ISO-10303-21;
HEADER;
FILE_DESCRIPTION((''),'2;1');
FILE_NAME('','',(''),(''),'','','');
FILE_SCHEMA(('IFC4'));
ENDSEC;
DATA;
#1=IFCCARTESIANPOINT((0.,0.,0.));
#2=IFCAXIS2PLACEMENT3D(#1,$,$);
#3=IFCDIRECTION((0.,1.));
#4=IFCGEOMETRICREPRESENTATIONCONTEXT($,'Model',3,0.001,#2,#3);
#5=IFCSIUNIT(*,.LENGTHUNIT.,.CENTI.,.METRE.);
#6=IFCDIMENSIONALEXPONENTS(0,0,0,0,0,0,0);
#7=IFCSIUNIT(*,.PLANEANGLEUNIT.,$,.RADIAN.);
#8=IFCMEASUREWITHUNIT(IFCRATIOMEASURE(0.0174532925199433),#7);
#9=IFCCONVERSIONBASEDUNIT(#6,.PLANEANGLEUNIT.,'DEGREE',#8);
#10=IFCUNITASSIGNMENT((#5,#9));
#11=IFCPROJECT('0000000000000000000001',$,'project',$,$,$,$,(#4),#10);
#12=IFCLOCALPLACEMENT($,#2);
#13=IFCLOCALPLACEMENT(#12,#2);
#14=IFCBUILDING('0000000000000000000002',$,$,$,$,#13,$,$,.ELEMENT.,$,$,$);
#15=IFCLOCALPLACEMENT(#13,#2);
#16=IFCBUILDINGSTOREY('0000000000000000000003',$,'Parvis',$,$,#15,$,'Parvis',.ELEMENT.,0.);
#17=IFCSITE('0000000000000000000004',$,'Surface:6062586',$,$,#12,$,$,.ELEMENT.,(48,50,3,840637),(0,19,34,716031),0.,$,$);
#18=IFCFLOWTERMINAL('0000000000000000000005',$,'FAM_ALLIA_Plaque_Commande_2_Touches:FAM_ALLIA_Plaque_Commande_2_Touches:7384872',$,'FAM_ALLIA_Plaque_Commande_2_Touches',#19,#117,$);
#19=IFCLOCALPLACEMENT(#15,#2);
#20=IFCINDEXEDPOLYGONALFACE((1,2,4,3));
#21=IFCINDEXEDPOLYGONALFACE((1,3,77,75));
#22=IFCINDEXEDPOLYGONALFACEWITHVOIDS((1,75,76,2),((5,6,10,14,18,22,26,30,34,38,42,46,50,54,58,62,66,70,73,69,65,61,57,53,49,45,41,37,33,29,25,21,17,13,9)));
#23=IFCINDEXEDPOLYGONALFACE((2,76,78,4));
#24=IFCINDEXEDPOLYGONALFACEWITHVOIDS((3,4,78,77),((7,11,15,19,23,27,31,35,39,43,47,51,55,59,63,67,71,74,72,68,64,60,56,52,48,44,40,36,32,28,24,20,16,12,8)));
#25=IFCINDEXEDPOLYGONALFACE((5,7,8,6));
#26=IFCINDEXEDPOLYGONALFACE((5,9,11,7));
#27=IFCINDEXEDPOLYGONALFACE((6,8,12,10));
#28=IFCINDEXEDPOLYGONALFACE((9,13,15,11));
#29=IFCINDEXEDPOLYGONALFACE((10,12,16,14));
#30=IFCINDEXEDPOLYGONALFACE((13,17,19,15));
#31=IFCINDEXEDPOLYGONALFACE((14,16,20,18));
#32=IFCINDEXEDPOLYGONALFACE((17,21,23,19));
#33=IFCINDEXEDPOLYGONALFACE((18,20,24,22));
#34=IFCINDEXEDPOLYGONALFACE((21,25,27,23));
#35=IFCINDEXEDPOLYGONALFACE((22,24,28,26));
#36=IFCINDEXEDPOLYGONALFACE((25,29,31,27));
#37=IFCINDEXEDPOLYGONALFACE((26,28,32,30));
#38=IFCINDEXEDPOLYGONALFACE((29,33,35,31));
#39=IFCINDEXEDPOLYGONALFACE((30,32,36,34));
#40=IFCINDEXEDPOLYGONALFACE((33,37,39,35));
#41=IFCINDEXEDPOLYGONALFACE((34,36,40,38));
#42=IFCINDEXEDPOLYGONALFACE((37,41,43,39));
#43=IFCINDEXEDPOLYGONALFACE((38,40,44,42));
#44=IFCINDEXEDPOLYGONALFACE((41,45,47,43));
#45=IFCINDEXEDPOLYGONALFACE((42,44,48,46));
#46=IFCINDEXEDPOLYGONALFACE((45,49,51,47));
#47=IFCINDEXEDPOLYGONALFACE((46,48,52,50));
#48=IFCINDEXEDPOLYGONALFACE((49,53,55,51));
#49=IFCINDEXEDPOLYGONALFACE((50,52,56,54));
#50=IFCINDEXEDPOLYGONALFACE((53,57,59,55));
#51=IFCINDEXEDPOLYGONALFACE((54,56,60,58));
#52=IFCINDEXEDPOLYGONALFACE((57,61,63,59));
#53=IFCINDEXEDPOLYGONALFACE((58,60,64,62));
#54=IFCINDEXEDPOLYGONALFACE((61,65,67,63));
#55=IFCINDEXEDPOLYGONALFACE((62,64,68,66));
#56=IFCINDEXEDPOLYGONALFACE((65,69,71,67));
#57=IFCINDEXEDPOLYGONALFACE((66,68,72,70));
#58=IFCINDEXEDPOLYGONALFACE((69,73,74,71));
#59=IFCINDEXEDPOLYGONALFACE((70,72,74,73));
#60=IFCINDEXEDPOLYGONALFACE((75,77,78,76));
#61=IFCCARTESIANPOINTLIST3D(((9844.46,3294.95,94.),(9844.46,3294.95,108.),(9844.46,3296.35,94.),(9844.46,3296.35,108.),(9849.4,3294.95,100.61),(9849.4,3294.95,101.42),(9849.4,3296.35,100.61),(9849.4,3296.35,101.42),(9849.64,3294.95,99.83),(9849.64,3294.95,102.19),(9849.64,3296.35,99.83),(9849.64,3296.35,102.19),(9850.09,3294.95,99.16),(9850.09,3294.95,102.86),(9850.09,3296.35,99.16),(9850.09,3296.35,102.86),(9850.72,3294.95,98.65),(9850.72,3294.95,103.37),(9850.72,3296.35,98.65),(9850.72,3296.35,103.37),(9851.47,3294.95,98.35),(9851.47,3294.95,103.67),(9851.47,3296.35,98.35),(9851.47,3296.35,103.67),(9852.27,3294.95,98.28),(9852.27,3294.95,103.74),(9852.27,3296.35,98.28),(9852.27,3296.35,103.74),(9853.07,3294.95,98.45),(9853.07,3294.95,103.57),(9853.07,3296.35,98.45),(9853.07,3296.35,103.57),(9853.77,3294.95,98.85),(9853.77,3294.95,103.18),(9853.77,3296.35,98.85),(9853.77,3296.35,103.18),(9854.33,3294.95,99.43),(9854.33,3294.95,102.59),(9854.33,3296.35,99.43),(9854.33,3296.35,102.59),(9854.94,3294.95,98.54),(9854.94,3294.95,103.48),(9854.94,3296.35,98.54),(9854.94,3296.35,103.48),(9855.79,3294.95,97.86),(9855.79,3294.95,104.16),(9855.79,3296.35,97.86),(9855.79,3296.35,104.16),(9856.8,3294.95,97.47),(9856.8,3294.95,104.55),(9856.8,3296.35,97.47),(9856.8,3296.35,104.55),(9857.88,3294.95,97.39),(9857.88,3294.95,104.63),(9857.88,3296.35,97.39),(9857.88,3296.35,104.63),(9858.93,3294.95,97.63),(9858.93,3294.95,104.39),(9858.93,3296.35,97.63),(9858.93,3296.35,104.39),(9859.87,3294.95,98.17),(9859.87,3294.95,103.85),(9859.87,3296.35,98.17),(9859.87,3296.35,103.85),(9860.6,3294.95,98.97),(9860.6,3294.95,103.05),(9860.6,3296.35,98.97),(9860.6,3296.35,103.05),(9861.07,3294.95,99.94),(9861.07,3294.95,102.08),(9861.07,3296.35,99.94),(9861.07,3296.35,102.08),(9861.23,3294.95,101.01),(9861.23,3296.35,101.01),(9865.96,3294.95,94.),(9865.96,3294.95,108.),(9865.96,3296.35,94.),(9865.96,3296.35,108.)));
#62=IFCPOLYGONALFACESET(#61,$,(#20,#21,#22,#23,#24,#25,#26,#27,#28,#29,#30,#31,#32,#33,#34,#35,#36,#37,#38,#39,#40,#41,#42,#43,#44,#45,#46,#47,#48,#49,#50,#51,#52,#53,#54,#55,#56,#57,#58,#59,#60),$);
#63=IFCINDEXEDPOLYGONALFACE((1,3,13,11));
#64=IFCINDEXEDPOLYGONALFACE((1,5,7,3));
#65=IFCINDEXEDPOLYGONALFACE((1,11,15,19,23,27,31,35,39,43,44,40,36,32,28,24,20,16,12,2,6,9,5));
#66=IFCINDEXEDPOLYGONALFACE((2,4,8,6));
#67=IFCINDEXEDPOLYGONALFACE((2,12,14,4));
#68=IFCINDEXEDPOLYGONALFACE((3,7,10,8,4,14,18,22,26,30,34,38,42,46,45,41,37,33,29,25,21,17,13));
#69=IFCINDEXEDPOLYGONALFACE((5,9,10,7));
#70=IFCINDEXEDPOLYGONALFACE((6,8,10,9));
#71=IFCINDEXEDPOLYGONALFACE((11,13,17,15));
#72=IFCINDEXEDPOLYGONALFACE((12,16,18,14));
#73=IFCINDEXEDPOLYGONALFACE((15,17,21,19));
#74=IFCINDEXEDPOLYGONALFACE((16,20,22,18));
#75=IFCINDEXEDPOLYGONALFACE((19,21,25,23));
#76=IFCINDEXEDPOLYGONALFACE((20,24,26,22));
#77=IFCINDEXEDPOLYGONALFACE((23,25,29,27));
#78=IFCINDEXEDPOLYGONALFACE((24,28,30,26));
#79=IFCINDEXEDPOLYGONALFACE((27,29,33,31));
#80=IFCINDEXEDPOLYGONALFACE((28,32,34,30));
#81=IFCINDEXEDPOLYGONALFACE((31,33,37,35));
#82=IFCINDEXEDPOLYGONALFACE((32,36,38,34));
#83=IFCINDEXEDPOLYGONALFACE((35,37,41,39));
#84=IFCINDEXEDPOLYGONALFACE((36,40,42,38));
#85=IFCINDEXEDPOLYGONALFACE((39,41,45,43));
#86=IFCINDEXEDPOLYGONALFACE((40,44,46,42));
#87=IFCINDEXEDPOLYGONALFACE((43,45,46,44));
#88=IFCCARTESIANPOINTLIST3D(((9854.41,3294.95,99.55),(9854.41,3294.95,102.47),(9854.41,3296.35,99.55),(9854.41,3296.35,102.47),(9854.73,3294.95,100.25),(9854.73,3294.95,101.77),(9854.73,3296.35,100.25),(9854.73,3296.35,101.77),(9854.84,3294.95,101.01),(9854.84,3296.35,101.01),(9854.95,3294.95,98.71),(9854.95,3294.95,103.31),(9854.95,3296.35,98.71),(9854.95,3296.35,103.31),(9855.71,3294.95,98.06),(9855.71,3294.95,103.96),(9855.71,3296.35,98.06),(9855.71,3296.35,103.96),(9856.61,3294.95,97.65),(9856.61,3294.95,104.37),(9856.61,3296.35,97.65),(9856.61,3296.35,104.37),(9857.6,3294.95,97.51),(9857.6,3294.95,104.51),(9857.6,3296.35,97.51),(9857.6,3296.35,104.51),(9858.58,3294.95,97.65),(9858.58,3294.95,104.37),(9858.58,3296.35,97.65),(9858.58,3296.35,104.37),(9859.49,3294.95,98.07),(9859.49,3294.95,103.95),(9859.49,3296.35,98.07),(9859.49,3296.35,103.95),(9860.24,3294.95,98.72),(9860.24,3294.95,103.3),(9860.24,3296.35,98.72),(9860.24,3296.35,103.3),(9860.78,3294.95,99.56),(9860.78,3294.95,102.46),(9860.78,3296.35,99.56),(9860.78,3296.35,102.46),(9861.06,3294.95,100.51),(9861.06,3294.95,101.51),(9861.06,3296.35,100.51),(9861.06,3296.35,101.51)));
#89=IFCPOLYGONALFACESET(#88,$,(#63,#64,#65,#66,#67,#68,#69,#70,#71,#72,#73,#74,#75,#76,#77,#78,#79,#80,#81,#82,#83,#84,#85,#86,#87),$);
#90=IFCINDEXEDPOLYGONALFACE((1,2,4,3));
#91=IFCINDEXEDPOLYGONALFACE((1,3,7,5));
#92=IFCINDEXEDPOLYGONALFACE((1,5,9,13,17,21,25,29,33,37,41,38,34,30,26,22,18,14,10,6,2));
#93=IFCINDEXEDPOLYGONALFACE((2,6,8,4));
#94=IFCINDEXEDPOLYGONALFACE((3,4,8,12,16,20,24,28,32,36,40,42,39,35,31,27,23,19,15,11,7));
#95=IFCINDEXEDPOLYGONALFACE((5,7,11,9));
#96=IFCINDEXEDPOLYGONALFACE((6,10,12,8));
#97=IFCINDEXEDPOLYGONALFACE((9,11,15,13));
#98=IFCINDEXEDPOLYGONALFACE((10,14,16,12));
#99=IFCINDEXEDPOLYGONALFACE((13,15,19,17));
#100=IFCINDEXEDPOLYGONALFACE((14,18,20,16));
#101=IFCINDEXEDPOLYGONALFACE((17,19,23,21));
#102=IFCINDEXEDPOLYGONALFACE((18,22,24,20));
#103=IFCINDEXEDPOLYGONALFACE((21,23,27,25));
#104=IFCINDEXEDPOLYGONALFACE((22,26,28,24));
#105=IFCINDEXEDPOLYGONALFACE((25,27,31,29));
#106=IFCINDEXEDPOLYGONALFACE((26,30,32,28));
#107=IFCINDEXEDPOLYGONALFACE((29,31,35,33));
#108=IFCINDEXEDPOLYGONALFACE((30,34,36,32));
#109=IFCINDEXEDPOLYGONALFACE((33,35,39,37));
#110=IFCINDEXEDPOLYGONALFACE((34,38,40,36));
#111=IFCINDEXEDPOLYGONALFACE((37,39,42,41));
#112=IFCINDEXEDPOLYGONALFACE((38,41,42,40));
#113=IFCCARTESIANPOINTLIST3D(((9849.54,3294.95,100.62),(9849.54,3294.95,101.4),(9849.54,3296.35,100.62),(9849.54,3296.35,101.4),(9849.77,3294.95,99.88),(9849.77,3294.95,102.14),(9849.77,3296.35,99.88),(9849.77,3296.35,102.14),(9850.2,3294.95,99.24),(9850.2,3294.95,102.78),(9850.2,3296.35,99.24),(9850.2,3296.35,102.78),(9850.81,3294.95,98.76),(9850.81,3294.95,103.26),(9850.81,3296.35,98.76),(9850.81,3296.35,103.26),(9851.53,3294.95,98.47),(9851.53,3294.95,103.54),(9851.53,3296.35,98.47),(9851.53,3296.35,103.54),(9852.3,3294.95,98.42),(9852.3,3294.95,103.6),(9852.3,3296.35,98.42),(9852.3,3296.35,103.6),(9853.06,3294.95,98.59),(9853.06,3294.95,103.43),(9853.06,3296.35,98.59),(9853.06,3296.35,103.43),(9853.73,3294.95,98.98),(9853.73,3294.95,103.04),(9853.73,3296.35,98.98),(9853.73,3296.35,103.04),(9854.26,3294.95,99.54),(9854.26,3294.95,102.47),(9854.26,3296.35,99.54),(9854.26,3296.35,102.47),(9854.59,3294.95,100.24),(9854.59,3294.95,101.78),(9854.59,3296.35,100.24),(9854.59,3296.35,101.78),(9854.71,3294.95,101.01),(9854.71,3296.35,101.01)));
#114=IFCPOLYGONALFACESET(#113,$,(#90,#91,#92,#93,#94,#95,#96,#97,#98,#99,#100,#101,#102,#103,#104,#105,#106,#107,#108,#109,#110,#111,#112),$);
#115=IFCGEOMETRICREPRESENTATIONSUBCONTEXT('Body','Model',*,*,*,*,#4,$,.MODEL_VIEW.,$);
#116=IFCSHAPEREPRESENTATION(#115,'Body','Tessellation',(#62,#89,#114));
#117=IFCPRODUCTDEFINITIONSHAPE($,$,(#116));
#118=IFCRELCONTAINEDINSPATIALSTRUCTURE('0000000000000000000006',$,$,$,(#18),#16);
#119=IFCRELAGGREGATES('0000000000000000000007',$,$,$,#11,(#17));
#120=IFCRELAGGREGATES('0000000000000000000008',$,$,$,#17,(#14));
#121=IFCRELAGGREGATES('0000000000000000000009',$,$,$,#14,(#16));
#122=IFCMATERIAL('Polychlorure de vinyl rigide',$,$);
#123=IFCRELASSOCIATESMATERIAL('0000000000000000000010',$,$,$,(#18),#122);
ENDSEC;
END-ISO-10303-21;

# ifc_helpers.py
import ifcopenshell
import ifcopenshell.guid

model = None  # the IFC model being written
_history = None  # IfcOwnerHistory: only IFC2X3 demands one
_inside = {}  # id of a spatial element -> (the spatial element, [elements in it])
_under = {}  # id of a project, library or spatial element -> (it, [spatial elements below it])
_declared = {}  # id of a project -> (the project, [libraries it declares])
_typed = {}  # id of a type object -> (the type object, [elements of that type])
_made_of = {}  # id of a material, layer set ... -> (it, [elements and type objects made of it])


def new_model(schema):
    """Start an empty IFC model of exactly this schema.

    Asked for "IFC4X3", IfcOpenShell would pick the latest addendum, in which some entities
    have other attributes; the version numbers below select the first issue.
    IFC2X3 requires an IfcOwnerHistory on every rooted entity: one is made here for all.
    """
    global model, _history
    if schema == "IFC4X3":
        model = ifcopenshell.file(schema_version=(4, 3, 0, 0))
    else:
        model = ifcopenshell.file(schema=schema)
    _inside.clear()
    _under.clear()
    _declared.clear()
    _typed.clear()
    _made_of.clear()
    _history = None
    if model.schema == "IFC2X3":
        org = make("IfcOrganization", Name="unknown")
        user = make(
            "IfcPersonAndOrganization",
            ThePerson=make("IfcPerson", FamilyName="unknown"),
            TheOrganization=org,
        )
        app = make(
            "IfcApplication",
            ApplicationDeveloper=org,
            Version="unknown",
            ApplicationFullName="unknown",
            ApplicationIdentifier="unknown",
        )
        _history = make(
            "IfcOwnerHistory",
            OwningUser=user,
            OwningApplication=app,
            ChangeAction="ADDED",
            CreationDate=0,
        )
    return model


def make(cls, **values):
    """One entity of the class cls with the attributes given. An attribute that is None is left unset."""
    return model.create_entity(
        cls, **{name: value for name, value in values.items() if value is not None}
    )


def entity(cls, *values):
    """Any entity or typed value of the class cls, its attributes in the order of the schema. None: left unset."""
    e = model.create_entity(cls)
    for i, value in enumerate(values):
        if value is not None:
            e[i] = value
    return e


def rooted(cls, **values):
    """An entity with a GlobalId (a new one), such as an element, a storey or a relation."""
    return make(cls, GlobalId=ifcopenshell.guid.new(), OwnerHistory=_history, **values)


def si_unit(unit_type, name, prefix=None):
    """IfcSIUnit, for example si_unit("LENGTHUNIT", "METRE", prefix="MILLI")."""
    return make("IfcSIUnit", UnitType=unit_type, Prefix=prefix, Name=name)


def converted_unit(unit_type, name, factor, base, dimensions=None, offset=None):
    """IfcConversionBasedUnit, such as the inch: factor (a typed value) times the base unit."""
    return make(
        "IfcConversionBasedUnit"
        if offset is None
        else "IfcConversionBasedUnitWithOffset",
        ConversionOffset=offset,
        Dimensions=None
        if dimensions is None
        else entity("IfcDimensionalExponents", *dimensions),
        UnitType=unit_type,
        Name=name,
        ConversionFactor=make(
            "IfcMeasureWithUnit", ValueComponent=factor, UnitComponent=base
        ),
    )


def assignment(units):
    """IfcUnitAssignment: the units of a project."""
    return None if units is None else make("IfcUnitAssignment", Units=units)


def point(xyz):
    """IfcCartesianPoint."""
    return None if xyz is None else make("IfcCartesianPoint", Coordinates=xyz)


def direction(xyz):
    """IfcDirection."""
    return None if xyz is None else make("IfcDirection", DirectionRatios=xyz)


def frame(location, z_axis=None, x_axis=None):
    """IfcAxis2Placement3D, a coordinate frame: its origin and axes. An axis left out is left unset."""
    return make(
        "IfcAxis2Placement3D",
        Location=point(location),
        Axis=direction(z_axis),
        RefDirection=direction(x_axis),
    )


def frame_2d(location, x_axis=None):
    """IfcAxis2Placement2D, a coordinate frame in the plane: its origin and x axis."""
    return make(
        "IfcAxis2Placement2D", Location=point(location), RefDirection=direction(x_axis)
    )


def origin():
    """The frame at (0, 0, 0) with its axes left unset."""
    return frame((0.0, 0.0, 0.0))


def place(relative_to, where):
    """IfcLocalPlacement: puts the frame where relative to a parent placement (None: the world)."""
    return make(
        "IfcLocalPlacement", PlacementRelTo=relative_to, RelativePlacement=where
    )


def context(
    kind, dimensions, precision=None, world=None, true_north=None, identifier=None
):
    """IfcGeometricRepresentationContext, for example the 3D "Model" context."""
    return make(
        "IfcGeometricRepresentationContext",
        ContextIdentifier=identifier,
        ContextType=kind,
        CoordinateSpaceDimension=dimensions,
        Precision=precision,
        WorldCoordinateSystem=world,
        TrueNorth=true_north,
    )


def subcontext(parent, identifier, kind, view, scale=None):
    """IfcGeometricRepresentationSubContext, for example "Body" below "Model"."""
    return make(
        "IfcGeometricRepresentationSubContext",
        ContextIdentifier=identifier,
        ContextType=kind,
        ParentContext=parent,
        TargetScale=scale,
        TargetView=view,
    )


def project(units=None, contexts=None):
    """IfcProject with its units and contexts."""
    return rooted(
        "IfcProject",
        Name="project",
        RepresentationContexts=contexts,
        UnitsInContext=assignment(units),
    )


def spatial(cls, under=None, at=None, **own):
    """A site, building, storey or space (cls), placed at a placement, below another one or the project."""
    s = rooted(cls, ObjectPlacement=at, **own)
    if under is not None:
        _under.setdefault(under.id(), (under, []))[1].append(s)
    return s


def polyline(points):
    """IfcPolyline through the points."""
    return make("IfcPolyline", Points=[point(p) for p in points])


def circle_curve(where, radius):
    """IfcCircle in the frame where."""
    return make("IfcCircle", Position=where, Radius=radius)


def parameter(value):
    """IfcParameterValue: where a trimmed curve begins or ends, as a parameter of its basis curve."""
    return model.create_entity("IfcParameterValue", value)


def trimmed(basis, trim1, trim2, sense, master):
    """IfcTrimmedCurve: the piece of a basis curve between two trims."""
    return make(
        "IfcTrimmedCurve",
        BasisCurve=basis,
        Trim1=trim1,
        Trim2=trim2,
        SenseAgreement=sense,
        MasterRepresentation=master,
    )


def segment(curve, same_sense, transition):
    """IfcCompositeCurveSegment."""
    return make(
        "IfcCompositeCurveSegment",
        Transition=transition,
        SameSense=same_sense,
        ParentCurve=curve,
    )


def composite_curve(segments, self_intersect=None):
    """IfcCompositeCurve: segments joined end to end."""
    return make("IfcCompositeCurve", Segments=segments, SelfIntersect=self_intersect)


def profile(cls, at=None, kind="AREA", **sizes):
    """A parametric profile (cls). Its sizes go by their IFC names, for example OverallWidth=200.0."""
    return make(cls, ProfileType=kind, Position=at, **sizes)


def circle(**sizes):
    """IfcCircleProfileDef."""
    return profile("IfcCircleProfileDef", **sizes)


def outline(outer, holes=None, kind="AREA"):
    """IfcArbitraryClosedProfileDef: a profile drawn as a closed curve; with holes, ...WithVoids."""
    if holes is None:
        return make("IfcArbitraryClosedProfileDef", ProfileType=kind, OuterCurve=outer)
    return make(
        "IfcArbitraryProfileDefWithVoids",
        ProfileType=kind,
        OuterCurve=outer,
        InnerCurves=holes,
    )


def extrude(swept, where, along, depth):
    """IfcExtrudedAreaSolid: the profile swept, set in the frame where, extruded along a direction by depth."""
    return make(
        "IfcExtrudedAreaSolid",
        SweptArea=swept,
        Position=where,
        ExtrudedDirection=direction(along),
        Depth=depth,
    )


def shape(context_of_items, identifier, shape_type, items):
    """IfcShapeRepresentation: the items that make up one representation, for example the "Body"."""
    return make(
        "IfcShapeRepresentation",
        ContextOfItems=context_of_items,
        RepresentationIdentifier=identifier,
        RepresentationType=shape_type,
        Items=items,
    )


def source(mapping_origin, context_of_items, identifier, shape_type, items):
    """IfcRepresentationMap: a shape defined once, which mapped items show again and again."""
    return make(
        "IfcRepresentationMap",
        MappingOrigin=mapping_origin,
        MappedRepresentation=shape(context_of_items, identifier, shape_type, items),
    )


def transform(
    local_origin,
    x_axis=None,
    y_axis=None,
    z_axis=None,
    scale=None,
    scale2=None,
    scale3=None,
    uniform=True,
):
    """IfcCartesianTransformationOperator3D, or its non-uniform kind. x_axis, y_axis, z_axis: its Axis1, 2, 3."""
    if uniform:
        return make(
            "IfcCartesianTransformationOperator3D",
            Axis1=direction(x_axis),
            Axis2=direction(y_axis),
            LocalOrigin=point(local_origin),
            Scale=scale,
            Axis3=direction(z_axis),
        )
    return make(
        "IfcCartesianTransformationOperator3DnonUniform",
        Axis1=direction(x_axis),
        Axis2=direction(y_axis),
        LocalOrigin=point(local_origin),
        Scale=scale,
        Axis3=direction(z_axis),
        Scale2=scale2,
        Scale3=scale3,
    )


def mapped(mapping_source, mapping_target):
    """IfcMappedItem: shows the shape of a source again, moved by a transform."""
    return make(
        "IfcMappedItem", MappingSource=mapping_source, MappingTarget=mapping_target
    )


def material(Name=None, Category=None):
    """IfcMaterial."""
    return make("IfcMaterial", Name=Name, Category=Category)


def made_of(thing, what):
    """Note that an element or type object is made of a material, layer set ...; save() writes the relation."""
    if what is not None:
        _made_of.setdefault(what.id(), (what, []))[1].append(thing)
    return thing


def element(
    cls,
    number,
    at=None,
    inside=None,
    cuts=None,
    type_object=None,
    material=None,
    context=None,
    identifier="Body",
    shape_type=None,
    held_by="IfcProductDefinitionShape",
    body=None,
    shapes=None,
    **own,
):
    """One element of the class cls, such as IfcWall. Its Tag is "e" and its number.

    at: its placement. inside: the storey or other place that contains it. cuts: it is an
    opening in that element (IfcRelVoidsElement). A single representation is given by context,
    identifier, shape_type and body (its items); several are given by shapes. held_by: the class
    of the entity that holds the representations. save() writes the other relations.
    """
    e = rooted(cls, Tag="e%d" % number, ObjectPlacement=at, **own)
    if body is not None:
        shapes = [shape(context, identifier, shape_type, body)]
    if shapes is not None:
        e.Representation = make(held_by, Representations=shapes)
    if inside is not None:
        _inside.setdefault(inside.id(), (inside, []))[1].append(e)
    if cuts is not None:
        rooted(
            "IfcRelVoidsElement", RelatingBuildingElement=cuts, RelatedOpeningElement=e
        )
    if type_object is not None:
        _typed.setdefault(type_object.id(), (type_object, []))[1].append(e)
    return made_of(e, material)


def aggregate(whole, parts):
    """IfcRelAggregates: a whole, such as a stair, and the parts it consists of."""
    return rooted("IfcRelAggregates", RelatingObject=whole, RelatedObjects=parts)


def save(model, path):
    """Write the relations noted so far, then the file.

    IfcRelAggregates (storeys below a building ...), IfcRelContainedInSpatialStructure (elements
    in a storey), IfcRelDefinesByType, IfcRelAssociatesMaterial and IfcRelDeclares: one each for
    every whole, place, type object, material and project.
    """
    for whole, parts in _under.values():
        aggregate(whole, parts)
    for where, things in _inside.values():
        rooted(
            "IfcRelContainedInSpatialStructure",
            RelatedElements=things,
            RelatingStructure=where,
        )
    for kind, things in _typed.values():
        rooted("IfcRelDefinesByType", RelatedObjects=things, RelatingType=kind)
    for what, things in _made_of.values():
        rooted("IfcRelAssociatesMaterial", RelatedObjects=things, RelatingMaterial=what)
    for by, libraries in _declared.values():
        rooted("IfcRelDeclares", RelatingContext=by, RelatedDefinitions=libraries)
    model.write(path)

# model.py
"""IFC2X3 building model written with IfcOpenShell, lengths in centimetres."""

from ifc_helpers import new_model, entity, si_unit, converted_unit, direction, frame, frame_2d, origin, place, context, subcontext, project, spatial, polyline, circle_curve, parameter, trimmed, segment, composite_curve, circle, outline, extrude, source, transform, mapped, material, element, save


model = new_model("IFC2X3")

# Units and contexts
model_context = context("Model", 3, precision=0.001, world=origin(), true_north=direction((0.0, 1.0)))
body_context = subcontext(model_context, "Body", "Model", "MODEL_VIEW")
ifc_project = project(units=[si_unit("LENGTHUNIT", "METRE", prefix="CENTI"), converted_unit("PLANEANGLEUNIT", "DEGREE", entity("IfcRatioMeasure", 0.0174532925199433), si_unit("PLANEANGLEUNIT", "RADIAN"), dimensions=[0, 0, 0, 0, 0, 0, 0])], contexts=[model_context])

# Site, building, storey
site_placement = place(None, origin())
site = spatial("IfcSite", under=ifc_project, at=site_placement, Name="Surface:6062586", CompositionType="ELEMENT", RefLatitude=(48, 50, 3, 840637), RefLongitude=(0, 19, 34, 716031), RefElevation=0.0)
building_placement = place(site_placement, origin())
building = spatial("IfcBuilding", under=site, at=building_placement, CompositionType="ELEMENT")
storey_placement = place(building_placement, frame((0.0, 0.0, 0.0)))
storey = spatial("IfcBuildingStorey", under=building, at=storey_placement, Name="Parvis", LongName="Parvis", CompositionType="ELEMENT", Elevation=0.0)

# Flow terminal
ifc_material_1 = material(Name="Polychlorure de vinyl rigide")
shared_shape_1 = source(origin(), body_context, "Body", "SweptSolid", [
    extrude(outline(polyline([(-10.75, -7.0), (10.75, -7.0), (10.75, 7.0), (-10.75, 7.0), (-10.75, -7.0)]), holes=[composite_curve([segment(trimmed(circle_curve(frame_2d((-3.1, 0.01), x_axis=(-1.0, 0.0)), 2.73), [parameter(215.328783)], [parameter(144.671217)], True, "PARAMETER"), False, "CONTINUOUS"), segment(trimmed(circle_curve(frame_2d((2.39, 0.01), x_axis=(-1.0, 0.0)), 3.63), [parameter(25.817037)], [parameter(334.182963)], True, "PARAMETER"), False, "CONTINUOUS")], self_intersect=False)]), frame((10.75, 0.0, 7.0), z_axis=(0.0, 1.0, 0.0), x_axis=(-1.0, 0.0, 0.0)), (0.0, 0.0, 1.0), 1.4),
    extrude(outline(composite_curve([segment(trimmed(circle_curve(frame_2d((-3.18, 0.0), x_axis=(1.0, 0.0)), 3.5), [parameter(24.630749)], [parameter(335.341392)], True, "PARAMETER"), True, "CONTINUOUS"), segment(trimmed(circle_curve(frame_2d((2.31, 0.0), x_axis=(1.0, 0.0)), 2.73), [parameter(147.719336)], [parameter(212.252805)], True, "PARAMETER"), False, "CONTINUOUS")], self_intersect=False)), frame((11.54, 0.0, 7.01), z_axis=(0.0, 1.0, 0.0), x_axis=(1.0, 0.0, 0.0)), (0.0, 0.0, 1.0), 1.4),
    extrude(circle(Radius=2.6, at=frame_2d((0.0, 0.0), x_axis=(1.0, 0.0))), frame((13.85, 0.0, 7.01), z_axis=(0.0, 1.0, 0.0), x_axis=(-1.0, 0.0, 0.0)), (0.0, 0.0, 1.0), 1.4),
])
for number, where, z_axis, x_axis, name in (
    (1, (9865.96, 3296.35, 94.0), (0.0, 0.0, 1.0), (-1.0, 0.0, 0.0), "FAM_ALLIA_Plaque_Commande_2_Touches:FAM_ALLIA_Plaque_Commande_2_Touches:7384872"),
):
    element("IfcFlowTerminal", number, at=place(storey_placement, frame(where, z_axis=z_axis, x_axis=x_axis)), inside=storey, material=ifc_material_1, Name=name, ObjectType="FAM_ALLIA_Plaque_Commande_2_Touches", context=body_context, shape_type="MappedRepresentation", body=[
        mapped(shared_shape_1, transform((0.0, 0.0, 0.0), scale=1.0)),
    ])

save(model, "model.ifc")
